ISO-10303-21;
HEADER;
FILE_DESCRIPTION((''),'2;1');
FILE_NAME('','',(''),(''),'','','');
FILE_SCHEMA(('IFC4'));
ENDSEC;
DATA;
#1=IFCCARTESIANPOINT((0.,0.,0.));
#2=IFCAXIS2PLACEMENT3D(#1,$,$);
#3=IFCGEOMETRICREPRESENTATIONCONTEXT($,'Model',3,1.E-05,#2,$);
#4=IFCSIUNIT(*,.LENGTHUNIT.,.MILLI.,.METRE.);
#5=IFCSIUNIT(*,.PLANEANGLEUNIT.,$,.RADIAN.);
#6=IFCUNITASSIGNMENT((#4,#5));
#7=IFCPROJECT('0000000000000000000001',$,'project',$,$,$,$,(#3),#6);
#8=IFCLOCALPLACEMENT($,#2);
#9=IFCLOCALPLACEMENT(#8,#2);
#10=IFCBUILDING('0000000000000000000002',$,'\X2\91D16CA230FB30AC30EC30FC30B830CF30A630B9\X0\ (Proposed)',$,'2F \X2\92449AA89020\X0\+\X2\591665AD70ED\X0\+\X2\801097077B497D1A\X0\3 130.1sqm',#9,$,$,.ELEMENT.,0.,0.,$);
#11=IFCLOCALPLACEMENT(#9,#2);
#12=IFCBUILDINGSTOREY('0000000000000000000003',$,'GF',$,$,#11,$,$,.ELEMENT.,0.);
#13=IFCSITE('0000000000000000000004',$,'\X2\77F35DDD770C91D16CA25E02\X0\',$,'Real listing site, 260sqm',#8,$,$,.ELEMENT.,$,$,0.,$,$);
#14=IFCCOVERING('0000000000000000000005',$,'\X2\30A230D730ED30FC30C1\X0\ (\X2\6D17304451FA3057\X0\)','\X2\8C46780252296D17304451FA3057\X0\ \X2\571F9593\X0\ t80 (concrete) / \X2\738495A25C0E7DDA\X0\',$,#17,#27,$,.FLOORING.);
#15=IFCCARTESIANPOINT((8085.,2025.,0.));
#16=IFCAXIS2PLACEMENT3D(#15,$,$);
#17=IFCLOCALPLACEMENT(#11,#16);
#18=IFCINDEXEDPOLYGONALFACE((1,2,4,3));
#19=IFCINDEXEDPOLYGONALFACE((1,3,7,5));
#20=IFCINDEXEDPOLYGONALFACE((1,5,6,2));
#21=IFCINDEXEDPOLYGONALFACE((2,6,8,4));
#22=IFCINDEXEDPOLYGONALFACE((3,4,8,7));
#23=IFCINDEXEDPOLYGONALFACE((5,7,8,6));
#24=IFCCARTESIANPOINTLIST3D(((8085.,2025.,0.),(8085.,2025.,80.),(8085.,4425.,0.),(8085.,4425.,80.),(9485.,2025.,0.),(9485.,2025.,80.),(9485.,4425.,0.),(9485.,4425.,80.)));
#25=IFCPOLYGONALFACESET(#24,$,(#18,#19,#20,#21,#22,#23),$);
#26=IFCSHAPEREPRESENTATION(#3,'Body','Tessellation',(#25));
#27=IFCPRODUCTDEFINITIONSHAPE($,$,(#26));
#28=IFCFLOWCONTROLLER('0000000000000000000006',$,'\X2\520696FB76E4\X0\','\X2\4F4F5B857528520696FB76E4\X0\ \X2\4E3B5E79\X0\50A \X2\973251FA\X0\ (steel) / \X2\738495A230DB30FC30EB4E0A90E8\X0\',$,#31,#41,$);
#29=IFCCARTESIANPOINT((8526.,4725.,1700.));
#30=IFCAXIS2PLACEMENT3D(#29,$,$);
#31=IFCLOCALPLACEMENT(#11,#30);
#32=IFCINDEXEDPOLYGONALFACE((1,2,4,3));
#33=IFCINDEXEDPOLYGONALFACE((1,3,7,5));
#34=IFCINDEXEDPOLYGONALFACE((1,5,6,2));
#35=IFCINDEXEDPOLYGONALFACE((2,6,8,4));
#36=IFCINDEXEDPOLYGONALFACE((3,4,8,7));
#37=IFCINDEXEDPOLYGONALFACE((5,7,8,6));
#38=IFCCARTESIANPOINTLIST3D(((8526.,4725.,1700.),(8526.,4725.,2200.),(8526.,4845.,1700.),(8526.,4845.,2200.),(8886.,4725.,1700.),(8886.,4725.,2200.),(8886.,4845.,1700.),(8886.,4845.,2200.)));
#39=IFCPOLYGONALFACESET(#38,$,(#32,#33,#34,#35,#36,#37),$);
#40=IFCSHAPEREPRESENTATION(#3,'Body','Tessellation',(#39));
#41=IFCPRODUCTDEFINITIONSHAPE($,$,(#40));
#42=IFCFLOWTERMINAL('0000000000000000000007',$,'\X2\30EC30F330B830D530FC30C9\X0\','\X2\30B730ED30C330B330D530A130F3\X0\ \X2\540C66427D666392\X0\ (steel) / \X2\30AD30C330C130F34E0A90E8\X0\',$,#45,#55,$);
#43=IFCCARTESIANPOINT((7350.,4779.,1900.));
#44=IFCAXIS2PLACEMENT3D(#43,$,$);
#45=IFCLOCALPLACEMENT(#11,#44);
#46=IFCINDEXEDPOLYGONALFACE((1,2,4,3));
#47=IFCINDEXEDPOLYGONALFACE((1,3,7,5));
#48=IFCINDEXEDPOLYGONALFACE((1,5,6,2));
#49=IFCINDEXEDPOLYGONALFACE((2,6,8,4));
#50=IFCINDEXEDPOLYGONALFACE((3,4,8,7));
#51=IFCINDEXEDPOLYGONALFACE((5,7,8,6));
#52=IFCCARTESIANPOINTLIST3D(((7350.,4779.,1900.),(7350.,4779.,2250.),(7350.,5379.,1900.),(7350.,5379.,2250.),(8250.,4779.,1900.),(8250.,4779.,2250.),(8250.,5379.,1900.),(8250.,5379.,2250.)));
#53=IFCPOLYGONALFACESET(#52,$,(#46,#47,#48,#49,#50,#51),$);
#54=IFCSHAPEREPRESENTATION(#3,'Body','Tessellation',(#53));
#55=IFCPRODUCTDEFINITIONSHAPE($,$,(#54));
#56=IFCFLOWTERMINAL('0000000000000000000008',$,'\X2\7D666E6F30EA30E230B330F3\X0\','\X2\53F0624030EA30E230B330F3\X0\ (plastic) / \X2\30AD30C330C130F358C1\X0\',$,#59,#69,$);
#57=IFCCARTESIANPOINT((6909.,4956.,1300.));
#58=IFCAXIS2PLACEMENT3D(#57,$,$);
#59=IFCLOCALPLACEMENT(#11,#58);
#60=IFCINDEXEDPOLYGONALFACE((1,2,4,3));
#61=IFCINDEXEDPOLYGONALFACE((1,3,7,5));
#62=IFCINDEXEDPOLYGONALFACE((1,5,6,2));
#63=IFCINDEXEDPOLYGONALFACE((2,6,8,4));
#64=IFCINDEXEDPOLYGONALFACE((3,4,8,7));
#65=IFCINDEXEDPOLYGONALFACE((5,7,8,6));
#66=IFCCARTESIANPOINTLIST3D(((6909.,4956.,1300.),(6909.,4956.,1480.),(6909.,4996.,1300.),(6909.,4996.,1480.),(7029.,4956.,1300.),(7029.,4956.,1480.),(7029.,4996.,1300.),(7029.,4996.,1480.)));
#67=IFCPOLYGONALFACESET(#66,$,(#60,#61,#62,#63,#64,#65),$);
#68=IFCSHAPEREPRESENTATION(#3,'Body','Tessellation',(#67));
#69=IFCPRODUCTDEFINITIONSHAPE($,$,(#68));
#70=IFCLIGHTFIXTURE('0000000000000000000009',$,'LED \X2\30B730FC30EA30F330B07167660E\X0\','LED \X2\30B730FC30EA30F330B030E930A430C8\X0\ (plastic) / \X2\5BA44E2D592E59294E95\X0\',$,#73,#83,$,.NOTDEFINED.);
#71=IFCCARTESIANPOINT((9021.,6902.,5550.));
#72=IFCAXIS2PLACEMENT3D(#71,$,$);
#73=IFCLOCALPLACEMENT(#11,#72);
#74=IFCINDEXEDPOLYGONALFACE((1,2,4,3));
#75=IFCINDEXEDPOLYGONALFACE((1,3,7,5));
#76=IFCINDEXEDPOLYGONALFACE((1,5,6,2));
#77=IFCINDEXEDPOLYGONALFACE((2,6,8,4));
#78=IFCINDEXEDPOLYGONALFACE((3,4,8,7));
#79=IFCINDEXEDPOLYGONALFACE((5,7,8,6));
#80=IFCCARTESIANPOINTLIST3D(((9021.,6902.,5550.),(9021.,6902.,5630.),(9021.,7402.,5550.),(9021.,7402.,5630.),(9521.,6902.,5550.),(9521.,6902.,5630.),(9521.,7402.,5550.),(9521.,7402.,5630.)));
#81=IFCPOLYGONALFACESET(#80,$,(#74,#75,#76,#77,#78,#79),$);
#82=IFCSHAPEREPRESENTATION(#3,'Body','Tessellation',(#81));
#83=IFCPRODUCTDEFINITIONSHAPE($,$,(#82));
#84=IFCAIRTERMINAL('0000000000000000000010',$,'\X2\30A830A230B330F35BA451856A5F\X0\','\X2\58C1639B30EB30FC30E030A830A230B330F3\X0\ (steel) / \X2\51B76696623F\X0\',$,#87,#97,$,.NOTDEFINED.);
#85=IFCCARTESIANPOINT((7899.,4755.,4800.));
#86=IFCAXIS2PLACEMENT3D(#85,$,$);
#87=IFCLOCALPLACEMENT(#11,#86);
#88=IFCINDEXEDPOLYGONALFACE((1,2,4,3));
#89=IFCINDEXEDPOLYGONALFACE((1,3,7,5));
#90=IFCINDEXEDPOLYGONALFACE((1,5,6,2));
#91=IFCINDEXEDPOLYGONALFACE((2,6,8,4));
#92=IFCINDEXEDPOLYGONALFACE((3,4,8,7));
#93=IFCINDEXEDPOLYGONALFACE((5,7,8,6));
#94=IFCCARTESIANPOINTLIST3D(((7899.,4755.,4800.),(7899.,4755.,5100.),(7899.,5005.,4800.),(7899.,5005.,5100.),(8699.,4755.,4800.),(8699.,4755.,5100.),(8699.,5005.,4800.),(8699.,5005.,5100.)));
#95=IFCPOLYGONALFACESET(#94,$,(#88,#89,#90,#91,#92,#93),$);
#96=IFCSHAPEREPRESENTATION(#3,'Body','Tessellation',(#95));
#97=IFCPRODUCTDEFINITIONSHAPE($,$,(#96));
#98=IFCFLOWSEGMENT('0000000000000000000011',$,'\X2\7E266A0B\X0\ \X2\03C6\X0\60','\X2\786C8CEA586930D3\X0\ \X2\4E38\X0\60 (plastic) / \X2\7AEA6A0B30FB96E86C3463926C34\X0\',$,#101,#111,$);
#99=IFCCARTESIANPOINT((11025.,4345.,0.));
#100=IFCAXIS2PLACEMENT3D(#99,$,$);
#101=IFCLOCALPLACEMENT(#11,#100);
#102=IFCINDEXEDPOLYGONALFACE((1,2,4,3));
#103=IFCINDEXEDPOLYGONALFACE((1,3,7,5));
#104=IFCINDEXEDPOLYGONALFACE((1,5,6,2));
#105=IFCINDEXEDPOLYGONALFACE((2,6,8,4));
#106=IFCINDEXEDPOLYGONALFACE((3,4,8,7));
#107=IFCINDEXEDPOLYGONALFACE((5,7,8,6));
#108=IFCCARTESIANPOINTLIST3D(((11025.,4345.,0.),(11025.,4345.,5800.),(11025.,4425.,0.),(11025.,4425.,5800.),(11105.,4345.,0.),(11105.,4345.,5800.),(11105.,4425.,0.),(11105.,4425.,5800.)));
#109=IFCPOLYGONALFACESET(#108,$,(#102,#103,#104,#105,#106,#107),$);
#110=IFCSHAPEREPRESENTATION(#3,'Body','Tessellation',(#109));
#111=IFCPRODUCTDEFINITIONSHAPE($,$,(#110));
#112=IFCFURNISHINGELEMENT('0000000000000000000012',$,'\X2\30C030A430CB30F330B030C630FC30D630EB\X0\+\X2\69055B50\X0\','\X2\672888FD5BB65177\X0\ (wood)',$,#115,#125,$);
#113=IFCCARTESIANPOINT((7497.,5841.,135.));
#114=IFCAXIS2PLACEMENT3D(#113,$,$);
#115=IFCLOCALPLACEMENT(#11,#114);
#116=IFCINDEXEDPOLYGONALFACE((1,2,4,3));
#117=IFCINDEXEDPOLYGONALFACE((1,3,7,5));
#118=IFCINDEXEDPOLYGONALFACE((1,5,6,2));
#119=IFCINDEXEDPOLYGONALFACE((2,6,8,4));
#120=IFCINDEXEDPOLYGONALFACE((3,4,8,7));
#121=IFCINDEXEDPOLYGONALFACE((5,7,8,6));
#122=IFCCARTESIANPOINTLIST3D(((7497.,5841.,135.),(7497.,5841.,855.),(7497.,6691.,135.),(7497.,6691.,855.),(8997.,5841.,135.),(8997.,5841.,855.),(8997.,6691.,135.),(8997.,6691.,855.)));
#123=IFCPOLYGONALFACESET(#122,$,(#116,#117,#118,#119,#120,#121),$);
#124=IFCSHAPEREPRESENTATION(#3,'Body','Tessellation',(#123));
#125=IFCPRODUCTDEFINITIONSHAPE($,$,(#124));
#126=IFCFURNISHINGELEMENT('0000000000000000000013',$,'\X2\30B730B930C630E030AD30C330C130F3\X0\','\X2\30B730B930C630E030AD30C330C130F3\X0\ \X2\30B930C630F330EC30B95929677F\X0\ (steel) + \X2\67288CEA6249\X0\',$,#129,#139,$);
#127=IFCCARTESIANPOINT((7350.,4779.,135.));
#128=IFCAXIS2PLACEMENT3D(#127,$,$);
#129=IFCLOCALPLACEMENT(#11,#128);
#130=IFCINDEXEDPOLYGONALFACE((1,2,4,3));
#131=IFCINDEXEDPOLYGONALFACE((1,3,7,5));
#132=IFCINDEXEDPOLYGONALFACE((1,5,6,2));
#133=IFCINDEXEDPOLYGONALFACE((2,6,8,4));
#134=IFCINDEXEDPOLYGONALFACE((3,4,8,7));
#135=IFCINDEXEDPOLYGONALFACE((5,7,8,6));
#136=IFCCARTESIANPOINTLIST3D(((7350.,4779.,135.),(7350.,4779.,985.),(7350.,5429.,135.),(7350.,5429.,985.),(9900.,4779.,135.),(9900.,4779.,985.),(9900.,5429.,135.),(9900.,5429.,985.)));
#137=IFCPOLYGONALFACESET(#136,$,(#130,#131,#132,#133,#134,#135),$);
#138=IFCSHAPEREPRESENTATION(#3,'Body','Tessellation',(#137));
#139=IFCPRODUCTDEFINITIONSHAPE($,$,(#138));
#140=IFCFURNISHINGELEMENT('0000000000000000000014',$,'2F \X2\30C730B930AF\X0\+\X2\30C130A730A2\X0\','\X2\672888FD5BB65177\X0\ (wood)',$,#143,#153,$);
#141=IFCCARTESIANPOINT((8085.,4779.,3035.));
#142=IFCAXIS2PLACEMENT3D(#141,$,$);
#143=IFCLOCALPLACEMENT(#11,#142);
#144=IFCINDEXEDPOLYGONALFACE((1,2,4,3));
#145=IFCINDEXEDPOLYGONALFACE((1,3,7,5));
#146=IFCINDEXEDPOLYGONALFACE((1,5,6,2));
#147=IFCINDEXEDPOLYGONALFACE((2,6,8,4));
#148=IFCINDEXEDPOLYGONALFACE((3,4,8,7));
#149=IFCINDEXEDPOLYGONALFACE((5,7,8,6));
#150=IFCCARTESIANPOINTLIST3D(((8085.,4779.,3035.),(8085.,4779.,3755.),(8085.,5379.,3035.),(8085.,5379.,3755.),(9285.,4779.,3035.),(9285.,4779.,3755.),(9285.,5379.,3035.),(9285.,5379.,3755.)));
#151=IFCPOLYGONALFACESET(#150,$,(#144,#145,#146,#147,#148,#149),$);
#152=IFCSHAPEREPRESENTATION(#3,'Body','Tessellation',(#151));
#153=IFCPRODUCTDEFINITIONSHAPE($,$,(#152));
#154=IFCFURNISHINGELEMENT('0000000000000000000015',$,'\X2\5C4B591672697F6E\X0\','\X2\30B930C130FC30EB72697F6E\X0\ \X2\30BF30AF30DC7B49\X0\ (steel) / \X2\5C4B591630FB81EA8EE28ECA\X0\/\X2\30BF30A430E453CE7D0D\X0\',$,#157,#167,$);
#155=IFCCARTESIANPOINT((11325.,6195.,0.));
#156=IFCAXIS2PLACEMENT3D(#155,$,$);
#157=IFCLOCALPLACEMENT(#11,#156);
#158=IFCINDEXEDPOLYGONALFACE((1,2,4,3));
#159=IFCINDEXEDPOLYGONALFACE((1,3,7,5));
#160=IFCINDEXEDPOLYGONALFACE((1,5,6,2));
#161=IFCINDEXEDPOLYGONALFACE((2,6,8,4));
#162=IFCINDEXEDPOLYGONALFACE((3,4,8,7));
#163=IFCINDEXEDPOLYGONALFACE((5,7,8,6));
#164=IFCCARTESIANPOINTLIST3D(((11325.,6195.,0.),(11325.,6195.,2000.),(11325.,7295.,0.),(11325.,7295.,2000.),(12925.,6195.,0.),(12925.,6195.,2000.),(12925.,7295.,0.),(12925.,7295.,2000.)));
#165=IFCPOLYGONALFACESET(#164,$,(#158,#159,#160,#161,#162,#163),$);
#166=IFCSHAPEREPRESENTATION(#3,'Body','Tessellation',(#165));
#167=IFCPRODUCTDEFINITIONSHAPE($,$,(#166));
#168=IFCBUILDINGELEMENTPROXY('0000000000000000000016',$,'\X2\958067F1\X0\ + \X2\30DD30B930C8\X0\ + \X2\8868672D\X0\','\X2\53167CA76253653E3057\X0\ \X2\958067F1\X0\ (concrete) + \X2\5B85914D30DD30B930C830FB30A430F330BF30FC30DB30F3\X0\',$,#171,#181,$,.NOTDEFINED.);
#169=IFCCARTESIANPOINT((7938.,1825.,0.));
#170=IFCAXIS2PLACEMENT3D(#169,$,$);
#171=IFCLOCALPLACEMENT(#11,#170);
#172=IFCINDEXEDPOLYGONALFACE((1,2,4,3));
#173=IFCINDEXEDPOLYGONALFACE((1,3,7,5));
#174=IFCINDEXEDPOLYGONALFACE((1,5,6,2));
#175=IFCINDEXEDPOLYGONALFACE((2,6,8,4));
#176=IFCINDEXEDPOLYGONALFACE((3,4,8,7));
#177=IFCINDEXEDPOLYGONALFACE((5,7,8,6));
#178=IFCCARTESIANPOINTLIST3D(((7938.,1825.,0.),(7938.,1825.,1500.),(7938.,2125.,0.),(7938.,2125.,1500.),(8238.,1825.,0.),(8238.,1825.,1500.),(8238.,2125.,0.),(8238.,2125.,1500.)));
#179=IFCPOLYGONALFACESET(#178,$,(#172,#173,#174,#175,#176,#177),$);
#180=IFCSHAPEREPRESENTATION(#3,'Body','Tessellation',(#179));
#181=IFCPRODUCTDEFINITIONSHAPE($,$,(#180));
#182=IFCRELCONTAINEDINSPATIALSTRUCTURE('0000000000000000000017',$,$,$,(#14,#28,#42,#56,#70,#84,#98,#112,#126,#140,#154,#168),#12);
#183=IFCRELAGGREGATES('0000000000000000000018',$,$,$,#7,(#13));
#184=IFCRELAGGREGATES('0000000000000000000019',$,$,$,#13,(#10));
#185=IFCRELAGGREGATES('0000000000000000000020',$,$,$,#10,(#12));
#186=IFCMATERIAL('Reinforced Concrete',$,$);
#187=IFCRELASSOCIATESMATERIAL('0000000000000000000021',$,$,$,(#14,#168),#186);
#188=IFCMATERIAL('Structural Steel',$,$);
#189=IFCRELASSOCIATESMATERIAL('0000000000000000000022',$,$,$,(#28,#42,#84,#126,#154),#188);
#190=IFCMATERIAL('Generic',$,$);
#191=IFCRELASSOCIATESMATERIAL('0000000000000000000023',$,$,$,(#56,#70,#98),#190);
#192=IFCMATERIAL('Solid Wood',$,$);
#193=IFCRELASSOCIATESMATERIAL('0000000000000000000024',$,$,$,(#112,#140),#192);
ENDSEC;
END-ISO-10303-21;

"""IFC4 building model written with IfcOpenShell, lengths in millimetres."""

from ifc_helpers import new_model, si_unit, frame, frame_2d, origin, place, context, project, spatial, rectangle, extrude, material, element, save


model = new_model("IFC4")

# Units and contexts
model_context = context("Model", 3, precision=1e-05, world=origin())
ifc_project = project(units=[si_unit("LENGTHUNIT", "METRE", prefix="MILLI"), si_unit("PLANEANGLEUNIT", "RADIAN")], contexts=[model_context])

# Site, building, storey
site_placement = place(None, origin())
site = spatial("IfcSite", under=ifc_project, at=site_placement, Name="石川県金沢市", ObjectType="Real listing site, 260sqm", CompositionType="ELEMENT", RefElevation=0.0)
building_placement = place(site_placement, origin())
building = spatial("IfcBuilding", under=site, at=building_placement, Name="金沢・ガレージハウス (Proposed)", ObjectType="2F 鉄骨造+外断热+耐震等級3 130.1sqm", CompositionType="ELEMENT", ElevationOfRefHeight=0.0, ElevationOfTerrain=0.0)
storey_placement = place(building_placement, origin())
storey = spatial("IfcBuildingStorey", under=building, at=storey_placement, Name="GF", CompositionType="ELEMENT", Elevation=0.0)

# Shared definitions
ifc_material_1 = material(Name="Solid Wood")
ifc_material_2 = material(Name="Structural Steel")

# Shared definitions
ifc_material_3 = material(Name="Reinforced Concrete")

# Covering
covering_placement = place(storey_placement, frame((8085.0, 2025.0, 0.0)))
element("IfcCovering", 1, at=covering_placement, inside=storey, material=ifc_material_3, Name="アプローチ (洗い出し)", Description="豆砂利洗い出し 土間 t80 (concrete) / 玄関導線", PredefinedType="FLOORING", context=model_context, shape_type="SweptSolid", body=[
    extrude(rectangle(XDim=1400.0, YDim=2400.0, at=frame_2d((700.0, 1200.0))), frame((8085.0, 2025.0, 0.0)), (0.0, 0.0, 1.0), 80.0),
])

# Flow controller
flow_controller_placement = place(storey_placement, frame((8526.0, 4725.0, 1700.0)))
element("IfcFlowController", 2, at=flow_controller_placement, inside=storey, material=ifc_material_2, Name="分電盤", Description="住宅用分電盤 主幹50A 露出 (steel) / 玄関ホール上部", context=model_context, shape_type="SweptSolid", body=[
    extrude(rectangle(XDim=360.0, YDim=120.0, at=frame_2d((180.0, 60.0))), frame((8526.0, 4725.0, 1700.0)), (0.0, 0.0, 1.0), 500.0),
])

# Flow terminals
flow_terminal_1_placement = place(storey_placement, frame((7350.0, 4779.0, 1900.0)))
element("IfcFlowTerminal", 3, at=flow_terminal_1_placement, inside=storey, material=ifc_material_2, Name="レンジフード", Description="シロッコファン 同時給排 (steel) / キッチン上部", context=model_context, shape_type="SweptSolid", body=[
    extrude(rectangle(XDim=900.0, YDim=600.0, at=frame_2d((450.0, 300.0))), frame((7350.0, 4779.0, 1900.0)), (0.0, 0.0, 1.0), 350.0),
])
ifc_material_4 = material(Name="Generic")
flow_terminal_2_placement = place(storey_placement, frame((6909.0, 4956.0, 1300.0)))
element("IfcFlowTerminal", 4, at=flow_terminal_2_placement, inside=storey, material=ifc_material_4, Name="給湯リモコン", Description="台所リモコン (plastic) / キッチン壁", context=model_context, shape_type="SweptSolid", body=[
    extrude(rectangle(XDim=120.0, YDim=40.0, at=frame_2d((60.0, 20.0))), frame((6909.0, 4956.0, 1300.0)), (0.0, 0.0, 1.0), 180.0),
])

# Light fixture
light_fixture_placement = place(storey_placement, frame((9021.0, 6902.0, 5550.0)))
element("IfcLightFixture", 5, at=light_fixture_placement, inside=storey, material=ifc_material_4, Name="LED シーリング照明", Description="LED シーリングライト (plastic) / 室中央天井", PredefinedType="NOTDEFINED", context=model_context, shape_type="SweptSolid", body=[
    extrude(rectangle(XDim=500.0, YDim=500.0, at=frame_2d((250.0, 250.0))), frame((9021.0, 6902.0, 5550.0)), (0.0, 0.0, 1.0), 80.0),
])

# Air terminal
air_terminal_placement = place(storey_placement, frame((7899.0, 4755.0, 4800.0)))
element("IfcAirTerminal", 6, at=air_terminal_placement, inside=storey, material=ifc_material_2, Name="エアコン室内機", Description="壁掛ルームエアコン (steel) / 冷暖房", PredefinedType="NOTDEFINED", context=model_context, shape_type="SweptSolid", body=[
    extrude(rectangle(XDim=800.0, YDim=250.0, at=frame_2d((400.0, 125.0))), frame((7899.0, 4755.0, 4800.0)), (0.0, 0.0, 1.0), 300.0),
])

# Flow segment
flow_segment_placement = place(storey_placement, frame((11025.0, 4345.0, 0.0)))
element("IfcFlowSegment", 7, at=flow_segment_placement, inside=storey, material=ifc_material_4, Name="縦樋 φ60", Description="硬質塩ビ 丸60 (plastic) / 竪樋・雨水排水", context=model_context, shape_type="SweptSolid", body=[
    extrude(rectangle(XDim=80.0, YDim=80.0, at=frame_2d((40.0, 40.0))), frame((11025.0, 4345.0, 0.0)), (0.0, 0.0, 1.0), 5800.0),
])

# Furnishing elements
furnishing_1_placement = place(storey_placement, frame((7497.0, 5841.0, 135.0)))
element("IfcFurnishingElement", 8, at=furnishing_1_placement, inside=storey, material=ifc_material_1, Name="ダイニングテーブル+椅子", Description="木製家具 (wood)", context=model_context, shape_type="SweptSolid", body=[
    extrude(rectangle(XDim=1500.0, YDim=850.0, at=frame_2d((750.0, 425.0))), frame((7497.0, 5841.0, 135.0)), (0.0, 0.0, 1.0), 720.0),
])
furnishing_2_placement = place(storey_placement, frame((7350.0, 4779.0, 135.0)))
element("IfcFurnishingElement", 9, at=furnishing_2_placement, inside=storey, material=ifc_material_2, Name="システムキッチン", Description="システムキッチン ステンレス天板 (steel) + 木質扉", context=model_context, shape_type="SweptSolid", body=[
    extrude(rectangle(XDim=2550.0, YDim=650.0, at=frame_2d((1275.0, 325.0))), frame((7350.0, 4779.0, 135.0)), (0.0, 0.0, 1.0), 850.0),
])
furnishing_3_placement = place(storey_placement, frame((8085.0, 4779.0, 3035.0)))
element("IfcFurnishingElement", 10, at=furnishing_3_placement, inside=storey, material=ifc_material_1, Name="2F デスク+チェア", Description="木製家具 (wood)", context=model_context, shape_type="SweptSolid", body=[
    extrude(rectangle(XDim=1200.0, YDim=600.0, at=frame_2d((600.0, 300.0))), frame((8085.0, 4779.0, 3035.0)), (0.0, 0.0, 1.0), 720.0),
])
furnishing_4_placement = place(storey_placement, frame((11325.0, 6195.0, 0.0)))
element("IfcFurnishingElement", 11, at=furnishing_4_placement, inside=storey, material=ifc_material_2, Name="屋外物置", Description="スチール物置 タクボ等 (steel) / 屋外・自転車/タイヤ収納", context=model_context, shape_type="SweptSolid", body=[
    extrude(rectangle(XDim=1600.0, YDim=1100.0, at=frame_2d((800.0, 550.0))), frame((11325.0, 6195.0, 0.0)), (0.0, 0.0, 1.0), 2000.0),
])

# Building element proxy
proxy_placement = place(storey_placement, frame((7938.0, 1825.0, 0.0)))
element("IfcBuildingElementProxy", 12, at=proxy_placement, inside=storey, material=ifc_material_3, Name="門柱 + ポスト + 表札", Description="化粧打放し 門柱 (concrete) + 宅配ポスト・インターホン", PredefinedType="NOTDEFINED", context=model_context, shape_type="SweptSolid", body=[
    extrude(rectangle(XDim=300.0, YDim=300.0, at=frame_2d((150.0, 150.0))), frame((7938.0, 1825.0, 0.0)), (0.0, 0.0, 1.0), 1500.0),
])

save(model, "model.ifc")
